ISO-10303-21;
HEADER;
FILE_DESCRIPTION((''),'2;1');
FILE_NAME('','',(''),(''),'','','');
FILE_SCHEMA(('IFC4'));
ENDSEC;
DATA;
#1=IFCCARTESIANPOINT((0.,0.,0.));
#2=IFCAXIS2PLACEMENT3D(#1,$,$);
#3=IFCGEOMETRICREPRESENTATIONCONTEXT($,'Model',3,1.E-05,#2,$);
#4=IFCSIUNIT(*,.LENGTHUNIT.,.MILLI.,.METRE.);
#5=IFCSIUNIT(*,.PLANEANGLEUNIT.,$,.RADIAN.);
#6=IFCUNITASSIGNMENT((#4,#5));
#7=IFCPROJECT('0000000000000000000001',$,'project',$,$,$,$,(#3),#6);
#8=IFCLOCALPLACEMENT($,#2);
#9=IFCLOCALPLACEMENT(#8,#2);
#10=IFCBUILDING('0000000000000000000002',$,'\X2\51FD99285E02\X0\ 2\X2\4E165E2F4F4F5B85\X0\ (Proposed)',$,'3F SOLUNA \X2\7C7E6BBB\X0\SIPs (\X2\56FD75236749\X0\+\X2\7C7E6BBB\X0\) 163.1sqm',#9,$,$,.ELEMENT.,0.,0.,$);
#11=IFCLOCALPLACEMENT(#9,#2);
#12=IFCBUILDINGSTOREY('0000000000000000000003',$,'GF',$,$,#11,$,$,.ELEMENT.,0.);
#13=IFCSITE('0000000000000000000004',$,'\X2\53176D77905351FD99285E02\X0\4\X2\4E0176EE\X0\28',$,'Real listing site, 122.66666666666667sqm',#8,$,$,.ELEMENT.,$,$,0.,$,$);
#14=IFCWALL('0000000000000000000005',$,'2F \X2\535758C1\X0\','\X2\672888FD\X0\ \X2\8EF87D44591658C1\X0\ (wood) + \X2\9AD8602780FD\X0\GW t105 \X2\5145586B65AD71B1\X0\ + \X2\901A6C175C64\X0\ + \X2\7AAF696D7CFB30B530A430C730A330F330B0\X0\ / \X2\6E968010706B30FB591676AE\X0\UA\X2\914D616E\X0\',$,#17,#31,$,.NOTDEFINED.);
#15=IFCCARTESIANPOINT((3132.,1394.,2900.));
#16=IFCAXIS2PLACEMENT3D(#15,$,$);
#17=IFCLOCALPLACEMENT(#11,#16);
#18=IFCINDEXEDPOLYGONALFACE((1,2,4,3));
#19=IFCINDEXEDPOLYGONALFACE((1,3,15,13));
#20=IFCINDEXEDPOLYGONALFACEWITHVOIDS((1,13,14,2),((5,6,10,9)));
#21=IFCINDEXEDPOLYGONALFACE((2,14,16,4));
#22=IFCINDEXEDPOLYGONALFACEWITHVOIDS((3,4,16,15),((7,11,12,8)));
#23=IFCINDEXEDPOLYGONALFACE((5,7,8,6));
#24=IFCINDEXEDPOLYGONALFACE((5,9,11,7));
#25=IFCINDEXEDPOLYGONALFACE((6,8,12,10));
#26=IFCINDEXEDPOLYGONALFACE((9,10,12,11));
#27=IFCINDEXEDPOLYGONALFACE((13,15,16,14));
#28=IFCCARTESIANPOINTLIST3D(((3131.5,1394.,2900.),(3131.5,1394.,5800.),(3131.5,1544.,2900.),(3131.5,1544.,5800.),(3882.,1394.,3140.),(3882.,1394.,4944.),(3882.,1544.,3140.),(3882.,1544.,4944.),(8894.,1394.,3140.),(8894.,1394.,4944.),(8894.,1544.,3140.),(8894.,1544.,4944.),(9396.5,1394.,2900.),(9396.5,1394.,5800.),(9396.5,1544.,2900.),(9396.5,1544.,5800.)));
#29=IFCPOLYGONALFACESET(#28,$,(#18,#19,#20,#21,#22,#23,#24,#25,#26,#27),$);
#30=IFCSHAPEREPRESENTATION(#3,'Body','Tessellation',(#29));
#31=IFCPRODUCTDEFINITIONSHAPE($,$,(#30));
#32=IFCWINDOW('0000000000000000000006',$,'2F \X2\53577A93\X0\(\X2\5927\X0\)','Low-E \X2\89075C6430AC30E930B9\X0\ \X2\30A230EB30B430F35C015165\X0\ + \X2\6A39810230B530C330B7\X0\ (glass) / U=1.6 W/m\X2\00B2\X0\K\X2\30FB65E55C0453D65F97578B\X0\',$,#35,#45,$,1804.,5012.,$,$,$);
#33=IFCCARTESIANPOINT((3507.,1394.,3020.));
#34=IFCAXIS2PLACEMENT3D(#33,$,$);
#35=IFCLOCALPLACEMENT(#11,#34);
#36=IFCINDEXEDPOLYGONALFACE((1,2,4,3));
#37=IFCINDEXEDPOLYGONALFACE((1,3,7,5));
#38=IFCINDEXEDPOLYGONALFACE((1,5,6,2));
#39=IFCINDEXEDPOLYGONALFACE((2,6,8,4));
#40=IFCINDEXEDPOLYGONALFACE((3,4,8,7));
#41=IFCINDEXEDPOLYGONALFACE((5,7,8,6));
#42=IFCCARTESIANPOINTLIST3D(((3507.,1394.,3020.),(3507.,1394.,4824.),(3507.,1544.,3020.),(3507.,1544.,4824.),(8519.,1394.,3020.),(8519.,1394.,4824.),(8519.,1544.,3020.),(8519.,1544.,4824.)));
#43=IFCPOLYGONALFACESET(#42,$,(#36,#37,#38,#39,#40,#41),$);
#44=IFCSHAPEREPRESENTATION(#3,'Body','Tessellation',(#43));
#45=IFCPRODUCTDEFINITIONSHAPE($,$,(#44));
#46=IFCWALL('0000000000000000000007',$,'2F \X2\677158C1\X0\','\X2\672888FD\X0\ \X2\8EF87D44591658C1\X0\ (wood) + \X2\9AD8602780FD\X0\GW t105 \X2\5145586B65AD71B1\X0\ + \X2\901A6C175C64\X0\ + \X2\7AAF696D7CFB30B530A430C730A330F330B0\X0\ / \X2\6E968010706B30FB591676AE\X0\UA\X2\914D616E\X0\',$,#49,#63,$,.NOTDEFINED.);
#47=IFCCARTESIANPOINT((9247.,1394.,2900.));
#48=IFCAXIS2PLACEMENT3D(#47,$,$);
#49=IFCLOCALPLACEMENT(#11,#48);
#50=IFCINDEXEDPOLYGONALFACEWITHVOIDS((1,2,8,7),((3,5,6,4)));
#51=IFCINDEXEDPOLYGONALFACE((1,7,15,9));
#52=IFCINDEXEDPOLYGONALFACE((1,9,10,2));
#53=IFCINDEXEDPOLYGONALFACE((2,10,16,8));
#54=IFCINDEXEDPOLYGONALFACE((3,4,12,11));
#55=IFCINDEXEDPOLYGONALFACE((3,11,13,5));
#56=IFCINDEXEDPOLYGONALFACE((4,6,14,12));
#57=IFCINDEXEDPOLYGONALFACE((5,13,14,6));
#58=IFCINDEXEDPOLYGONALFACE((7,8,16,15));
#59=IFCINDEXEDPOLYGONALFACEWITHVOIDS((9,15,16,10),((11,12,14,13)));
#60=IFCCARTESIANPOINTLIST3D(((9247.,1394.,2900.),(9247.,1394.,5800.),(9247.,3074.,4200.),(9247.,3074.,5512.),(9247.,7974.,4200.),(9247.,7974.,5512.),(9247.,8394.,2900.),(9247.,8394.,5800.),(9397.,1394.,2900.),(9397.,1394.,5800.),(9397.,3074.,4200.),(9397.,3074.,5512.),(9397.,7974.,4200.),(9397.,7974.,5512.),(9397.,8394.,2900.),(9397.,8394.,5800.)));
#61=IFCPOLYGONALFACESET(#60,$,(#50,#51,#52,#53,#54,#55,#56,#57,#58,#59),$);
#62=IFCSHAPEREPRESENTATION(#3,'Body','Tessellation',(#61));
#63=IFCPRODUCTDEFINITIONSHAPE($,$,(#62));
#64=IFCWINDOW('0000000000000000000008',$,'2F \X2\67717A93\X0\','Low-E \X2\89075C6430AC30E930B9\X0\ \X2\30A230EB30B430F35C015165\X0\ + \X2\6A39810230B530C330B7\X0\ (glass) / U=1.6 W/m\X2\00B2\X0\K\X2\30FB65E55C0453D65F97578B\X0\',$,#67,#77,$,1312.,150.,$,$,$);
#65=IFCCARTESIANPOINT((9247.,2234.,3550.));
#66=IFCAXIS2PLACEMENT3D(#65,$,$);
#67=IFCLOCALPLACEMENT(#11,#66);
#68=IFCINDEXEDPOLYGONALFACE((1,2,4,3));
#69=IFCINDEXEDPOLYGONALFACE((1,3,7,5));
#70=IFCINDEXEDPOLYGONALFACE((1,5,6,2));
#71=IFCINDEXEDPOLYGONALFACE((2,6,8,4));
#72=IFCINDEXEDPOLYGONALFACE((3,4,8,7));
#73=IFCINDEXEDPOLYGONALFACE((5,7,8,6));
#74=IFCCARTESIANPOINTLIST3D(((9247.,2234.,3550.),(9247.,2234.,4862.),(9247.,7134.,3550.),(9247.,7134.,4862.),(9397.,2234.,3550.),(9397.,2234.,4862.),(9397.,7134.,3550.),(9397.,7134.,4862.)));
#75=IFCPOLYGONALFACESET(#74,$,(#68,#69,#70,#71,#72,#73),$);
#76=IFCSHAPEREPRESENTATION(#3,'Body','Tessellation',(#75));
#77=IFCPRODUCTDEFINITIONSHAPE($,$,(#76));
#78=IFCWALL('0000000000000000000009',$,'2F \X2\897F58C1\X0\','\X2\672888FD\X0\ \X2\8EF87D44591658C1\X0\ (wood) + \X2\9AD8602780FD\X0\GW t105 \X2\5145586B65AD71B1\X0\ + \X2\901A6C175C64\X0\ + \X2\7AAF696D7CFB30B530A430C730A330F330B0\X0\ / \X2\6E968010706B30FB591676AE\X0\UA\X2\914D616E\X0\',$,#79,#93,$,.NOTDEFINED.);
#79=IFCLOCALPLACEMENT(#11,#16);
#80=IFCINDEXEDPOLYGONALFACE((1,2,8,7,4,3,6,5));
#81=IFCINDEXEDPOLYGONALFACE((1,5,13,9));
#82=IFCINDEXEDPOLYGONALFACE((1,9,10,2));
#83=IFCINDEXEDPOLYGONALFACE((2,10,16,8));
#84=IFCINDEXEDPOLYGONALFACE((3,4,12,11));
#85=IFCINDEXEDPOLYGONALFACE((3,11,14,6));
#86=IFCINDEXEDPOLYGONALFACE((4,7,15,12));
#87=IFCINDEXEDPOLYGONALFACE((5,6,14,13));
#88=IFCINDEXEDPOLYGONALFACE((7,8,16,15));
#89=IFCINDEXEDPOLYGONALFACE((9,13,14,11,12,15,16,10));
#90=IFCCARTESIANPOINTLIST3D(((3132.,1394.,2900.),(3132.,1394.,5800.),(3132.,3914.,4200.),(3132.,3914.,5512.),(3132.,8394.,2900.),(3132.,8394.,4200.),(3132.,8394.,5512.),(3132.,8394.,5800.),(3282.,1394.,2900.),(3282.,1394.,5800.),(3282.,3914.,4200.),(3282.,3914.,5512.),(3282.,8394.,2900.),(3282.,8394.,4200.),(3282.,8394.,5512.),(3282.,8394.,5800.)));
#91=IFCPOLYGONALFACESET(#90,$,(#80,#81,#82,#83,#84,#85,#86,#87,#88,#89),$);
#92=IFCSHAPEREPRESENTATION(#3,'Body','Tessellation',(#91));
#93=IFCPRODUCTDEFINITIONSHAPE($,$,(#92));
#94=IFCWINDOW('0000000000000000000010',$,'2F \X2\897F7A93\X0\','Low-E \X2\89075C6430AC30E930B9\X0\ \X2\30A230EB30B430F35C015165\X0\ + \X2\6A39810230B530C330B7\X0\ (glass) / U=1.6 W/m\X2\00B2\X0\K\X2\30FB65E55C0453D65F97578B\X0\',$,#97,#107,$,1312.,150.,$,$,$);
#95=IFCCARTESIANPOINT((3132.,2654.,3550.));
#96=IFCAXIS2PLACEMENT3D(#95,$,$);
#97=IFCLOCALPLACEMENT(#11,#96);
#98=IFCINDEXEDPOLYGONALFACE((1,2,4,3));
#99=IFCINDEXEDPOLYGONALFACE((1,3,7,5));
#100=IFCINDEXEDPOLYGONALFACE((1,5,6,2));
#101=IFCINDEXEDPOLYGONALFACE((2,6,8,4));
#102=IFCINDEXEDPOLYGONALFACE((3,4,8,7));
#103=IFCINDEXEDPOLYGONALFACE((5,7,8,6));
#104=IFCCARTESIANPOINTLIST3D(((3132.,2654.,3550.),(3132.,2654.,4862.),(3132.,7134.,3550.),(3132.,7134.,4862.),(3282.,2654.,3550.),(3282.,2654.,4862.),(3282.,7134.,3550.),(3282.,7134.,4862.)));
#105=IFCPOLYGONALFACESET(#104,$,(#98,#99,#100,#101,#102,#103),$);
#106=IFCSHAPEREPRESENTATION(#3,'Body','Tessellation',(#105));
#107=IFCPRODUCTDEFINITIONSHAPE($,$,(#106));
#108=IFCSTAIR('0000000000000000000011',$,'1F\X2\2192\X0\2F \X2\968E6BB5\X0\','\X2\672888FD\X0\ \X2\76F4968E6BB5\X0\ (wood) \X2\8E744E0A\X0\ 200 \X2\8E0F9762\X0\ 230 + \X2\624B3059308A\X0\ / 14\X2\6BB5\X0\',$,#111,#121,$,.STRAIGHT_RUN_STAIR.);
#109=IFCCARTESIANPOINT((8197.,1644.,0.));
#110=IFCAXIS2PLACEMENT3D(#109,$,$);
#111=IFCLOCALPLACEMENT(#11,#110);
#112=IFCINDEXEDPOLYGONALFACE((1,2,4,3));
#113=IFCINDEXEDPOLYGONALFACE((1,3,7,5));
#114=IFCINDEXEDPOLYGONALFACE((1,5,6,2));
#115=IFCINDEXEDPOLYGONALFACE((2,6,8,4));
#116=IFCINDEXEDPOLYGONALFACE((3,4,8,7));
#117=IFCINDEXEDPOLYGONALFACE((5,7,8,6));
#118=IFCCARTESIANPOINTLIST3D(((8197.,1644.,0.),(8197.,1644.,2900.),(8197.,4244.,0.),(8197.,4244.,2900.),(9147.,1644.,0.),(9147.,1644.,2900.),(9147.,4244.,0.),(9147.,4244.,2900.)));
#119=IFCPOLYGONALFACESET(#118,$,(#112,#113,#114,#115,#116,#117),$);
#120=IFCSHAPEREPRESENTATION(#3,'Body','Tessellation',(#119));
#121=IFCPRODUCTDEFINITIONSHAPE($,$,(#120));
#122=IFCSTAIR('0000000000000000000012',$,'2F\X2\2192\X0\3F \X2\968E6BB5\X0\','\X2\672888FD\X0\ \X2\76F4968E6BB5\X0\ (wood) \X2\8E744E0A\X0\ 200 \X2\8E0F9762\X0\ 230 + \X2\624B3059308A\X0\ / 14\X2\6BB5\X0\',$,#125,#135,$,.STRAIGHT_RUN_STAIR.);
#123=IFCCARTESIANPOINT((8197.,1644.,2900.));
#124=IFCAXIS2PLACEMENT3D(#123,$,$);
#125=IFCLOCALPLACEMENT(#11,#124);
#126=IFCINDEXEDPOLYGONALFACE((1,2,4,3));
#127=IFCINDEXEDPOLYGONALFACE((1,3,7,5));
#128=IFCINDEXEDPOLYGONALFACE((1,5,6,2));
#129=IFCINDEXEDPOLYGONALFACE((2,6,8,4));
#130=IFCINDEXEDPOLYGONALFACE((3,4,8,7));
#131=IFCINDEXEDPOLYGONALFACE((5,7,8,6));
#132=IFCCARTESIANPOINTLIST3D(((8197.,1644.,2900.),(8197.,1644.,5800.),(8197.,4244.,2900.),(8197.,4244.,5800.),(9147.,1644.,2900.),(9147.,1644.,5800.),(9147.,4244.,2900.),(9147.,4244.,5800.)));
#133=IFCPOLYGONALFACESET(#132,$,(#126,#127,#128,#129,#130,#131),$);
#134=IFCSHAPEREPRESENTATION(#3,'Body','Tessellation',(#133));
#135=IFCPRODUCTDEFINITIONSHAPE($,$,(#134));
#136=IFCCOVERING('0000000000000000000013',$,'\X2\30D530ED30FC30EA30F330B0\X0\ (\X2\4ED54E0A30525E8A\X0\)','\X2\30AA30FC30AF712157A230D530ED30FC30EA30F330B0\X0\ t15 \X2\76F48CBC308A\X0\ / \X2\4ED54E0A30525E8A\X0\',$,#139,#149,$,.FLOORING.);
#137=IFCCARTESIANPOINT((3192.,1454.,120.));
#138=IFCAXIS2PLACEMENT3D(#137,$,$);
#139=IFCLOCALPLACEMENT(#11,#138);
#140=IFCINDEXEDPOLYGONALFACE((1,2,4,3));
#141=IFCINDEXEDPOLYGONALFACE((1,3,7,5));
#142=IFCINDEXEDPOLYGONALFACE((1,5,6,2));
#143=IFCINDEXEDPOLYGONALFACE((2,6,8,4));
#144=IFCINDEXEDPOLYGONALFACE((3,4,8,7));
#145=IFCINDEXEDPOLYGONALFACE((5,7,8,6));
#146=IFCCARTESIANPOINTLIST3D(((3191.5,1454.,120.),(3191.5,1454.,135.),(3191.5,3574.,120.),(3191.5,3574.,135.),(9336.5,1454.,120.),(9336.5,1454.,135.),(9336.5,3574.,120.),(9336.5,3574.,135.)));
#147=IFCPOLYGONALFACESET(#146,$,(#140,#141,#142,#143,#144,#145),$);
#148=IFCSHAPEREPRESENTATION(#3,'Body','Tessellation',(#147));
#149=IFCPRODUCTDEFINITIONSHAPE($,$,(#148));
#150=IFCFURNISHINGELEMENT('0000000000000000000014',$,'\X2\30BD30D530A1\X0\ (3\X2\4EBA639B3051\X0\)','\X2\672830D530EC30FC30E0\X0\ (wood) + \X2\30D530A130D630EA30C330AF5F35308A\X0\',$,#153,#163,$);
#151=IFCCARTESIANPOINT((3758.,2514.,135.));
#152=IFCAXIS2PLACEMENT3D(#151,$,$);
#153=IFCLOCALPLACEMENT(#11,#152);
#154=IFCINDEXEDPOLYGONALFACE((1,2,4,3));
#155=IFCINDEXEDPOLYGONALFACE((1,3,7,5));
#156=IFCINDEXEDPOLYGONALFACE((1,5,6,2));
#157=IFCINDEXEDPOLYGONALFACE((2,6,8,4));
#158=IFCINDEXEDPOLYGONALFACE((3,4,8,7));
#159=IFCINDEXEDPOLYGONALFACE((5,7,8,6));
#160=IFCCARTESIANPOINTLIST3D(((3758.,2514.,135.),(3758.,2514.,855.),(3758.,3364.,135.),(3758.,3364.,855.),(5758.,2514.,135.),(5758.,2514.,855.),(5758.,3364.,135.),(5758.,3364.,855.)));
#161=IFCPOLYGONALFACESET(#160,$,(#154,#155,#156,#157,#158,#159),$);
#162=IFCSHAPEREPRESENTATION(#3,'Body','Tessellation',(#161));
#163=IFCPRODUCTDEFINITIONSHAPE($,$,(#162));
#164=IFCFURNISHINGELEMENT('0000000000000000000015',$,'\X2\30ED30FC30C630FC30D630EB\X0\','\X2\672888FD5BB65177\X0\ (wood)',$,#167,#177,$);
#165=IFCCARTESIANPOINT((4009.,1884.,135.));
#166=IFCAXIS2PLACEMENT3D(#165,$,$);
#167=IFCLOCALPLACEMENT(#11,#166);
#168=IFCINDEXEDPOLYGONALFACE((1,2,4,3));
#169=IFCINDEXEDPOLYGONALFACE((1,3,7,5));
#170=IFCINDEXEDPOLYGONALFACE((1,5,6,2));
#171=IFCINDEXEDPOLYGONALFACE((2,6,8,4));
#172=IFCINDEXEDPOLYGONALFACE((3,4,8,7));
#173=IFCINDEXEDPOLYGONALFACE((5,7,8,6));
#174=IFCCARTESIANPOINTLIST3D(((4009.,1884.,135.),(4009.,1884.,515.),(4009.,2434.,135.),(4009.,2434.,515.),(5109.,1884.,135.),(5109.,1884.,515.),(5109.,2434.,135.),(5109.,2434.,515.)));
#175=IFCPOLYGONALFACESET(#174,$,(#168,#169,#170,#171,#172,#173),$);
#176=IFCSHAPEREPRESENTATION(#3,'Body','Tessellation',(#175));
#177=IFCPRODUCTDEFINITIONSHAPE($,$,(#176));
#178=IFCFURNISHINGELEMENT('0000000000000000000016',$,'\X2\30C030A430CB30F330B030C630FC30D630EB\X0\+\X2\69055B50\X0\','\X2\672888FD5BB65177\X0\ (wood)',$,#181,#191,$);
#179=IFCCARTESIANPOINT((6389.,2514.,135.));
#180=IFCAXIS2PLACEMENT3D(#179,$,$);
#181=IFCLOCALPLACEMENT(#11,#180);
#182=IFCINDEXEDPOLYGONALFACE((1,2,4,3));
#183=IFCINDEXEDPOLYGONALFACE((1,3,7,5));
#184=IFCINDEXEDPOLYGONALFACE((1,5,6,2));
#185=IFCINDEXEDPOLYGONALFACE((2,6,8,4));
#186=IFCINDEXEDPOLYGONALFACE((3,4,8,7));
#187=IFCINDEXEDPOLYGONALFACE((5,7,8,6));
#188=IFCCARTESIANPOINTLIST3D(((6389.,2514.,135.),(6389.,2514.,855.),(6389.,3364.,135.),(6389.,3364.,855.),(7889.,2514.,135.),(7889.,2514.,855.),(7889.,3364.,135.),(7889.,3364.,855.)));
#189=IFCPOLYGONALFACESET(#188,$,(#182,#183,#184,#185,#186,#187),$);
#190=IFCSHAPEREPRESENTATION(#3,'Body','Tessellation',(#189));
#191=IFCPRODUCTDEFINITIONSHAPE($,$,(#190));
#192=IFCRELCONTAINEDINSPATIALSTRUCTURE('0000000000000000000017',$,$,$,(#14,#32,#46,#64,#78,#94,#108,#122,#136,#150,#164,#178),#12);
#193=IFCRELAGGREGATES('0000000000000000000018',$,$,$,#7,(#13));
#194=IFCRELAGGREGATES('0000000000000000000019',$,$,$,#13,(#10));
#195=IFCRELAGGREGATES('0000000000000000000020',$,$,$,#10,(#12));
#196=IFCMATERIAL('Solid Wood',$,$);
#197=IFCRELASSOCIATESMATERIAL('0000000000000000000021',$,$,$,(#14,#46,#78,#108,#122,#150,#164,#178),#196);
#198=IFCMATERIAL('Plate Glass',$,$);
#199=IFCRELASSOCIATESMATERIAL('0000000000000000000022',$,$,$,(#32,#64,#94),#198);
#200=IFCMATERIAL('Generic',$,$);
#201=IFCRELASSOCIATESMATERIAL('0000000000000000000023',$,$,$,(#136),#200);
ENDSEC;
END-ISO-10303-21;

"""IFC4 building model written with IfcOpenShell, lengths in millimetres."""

from ifc_helpers import new_model, si_unit, frame, frame_2d, origin, place, context, project, spatial, rectangle, extrude, material, element, fill, save


model = new_model("IFC4")

# Units and contexts
model_context = context("Model", 3, precision=1e-05, world=origin())
ifc_project = project(units=[si_unit("LENGTHUNIT", "METRE", prefix="MILLI"), si_unit("PLANEANGLEUNIT", "RADIAN")], contexts=[model_context])

# Site, building, storey
site_placement = place(None, origin())
site = spatial("IfcSite", under=ifc_project, at=site_placement, Name="北海道函館市4丁目28", ObjectType="Real listing site, 122.66666666666667sqm", CompositionType="ELEMENT", RefElevation=0.0)
building_placement = place(site_placement, origin())
building = spatial("IfcBuilding", under=site, at=building_placement, Name="函館市 2世帯住宅 (Proposed)", ObjectType="3F SOLUNA 籾殻SIPs (国産杉+籾殻) 163.1sqm", CompositionType="ELEMENT", ElevationOfRefHeight=0.0, ElevationOfTerrain=0.0)
storey_placement = place(building_placement, origin())
storey = spatial("IfcBuildingStorey", under=building, at=storey_placement, Name="GF", CompositionType="ELEMENT", Elevation=0.0)

# Shared definitions
ifc_material_1 = material(Name="Solid Wood")

# Shared definitions
ifc_material_2 = material(Name="Plate Glass")

# Walls, openings, windows
wall_1_placement = place(storey_placement, frame((3132.0, 1394.0, 2900.0)))
wall_1 = element("IfcWall", 1, at=wall_1_placement, inside=storey, material=ifc_material_1, Name="2F 南壁", Description="木製 軸組外壁 (wood) + 高性能GW t105 充填断熱 + 通気層 + 窯業系サイディング / 準耐火・外皮UA配慮", PredefinedType="NOTDEFINED", context=model_context, shape_type="SweptSolid", body=[
    extrude(rectangle(XDim=6265.0, YDim=150.0, at=frame_2d((3132.0, 75.0))), frame((3132.0, 1394.0, 2900.0)), (0.0, 0.0, 1.0), 2900.0),
])
opening_1_placement = place(storey_placement, frame((3507.0, 1394.0, 3020.0)))
opening_1 = element("IfcOpeningElement", 2, at=opening_1_placement, cuts=wall_1, PredefinedType="NOTDEFINED", context=model_context, shape_type="SweptSolid", body=[
    extrude(rectangle(XDim=5012.0, YDim=150.0, at=frame_2d((2506.0, 75.0))), frame((3507.0, 1394.0, 3020.0)), (0.0, 0.0, 1.0), 1804.0),
])
window_1_placement = place(storey_placement, frame((3507.0, 1394.0, 3020.0)))
window_1 = element("IfcWindow", 3, at=window_1_placement, inside=storey, material=ifc_material_2, Name="2F 南窓(大)", Description="Low-E 複層ガラス アルゴン封入 + 樹脂サッシ (glass) / U=1.6 W/m²K・日射取得型", OverallHeight=1804.0, OverallWidth=5012.0, context=model_context, shape_type="SweptSolid", body=[
    extrude(rectangle(XDim=5012.0, YDim=150.0, at=frame_2d((2506.0, 75.0))), frame((3507.0, 1394.0, 3020.0)), (0.0, 0.0, 1.0), 1804.0),
])
fill(opening_1, window_1)
wall_2_placement = place(storey_placement, frame((9247.0, 1394.0, 2900.0)))
wall_2 = element("IfcWall", 4, at=wall_2_placement, inside=storey, material=ifc_material_1, Name="2F 東壁", Description="木製 軸組外壁 (wood) + 高性能GW t105 充填断熱 + 通気層 + 窯業系サイディング / 準耐火・外皮UA配慮", PredefinedType="NOTDEFINED", context=model_context, shape_type="SweptSolid", body=[
    extrude(rectangle(XDim=150.0, YDim=7000.0, at=frame_2d((75.0, 3500.0))), frame((9247.0, 1394.0, 2900.0)), (0.0, 0.0, 1.0), 2900.0),
])
opening_2_placement = place(storey_placement, frame((9247.0, 2234.0, 3550.0)))
opening_2 = element("IfcOpeningElement", 5, at=opening_2_placement, cuts=wall_2, PredefinedType="NOTDEFINED", context=model_context, shape_type="SweptSolid", body=[
    extrude(rectangle(XDim=150.0, YDim=4900.0, at=frame_2d((75.0, 2450.0))), frame((9247.0, 2234.0, 3550.0)), (0.0, 0.0, 1.0), 1312.0),
])
window_2_placement = place(storey_placement, frame((9247.0, 2234.0, 3550.0)))
window_2 = element("IfcWindow", 6, at=window_2_placement, inside=storey, material=ifc_material_2, Name="2F 東窓", Description="Low-E 複層ガラス アルゴン封入 + 樹脂サッシ (glass) / U=1.6 W/m²K・日射取得型", OverallHeight=1312.0, OverallWidth=150.0, context=model_context, shape_type="SweptSolid", body=[
    extrude(rectangle(XDim=150.0, YDim=4900.0, at=frame_2d((75.0, 2450.0))), frame((9247.0, 2234.0, 3550.0)), (0.0, 0.0, 1.0), 1312.0),
])
fill(opening_2, window_2)
wall_3_placement = place(storey_placement, frame((3132.0, 1394.0, 2900.0)))
wall_3 = element("IfcWall", 7, at=wall_3_placement, inside=storey, material=ifc_material_1, Name="2F 西壁", Description="木製 軸組外壁 (wood) + 高性能GW t105 充填断熱 + 通気層 + 窯業系サイディング / 準耐火・外皮UA配慮", PredefinedType="NOTDEFINED", context=model_context, shape_type="SweptSolid", body=[
    extrude(rectangle(XDim=150.0, YDim=7000.0, at=frame_2d((75.0, 3500.0))), frame((3132.0, 1394.0, 2900.0)), (0.0, 0.0, 1.0), 2900.0),
])
opening_3_placement = place(storey_placement, frame((3132.0, 2654.0, 3550.0)))
opening_3 = element("IfcOpeningElement", 8, at=opening_3_placement, cuts=wall_3, PredefinedType="NOTDEFINED", context=model_context, shape_type="SweptSolid", body=[
    extrude(rectangle(XDim=150.0, YDim=4480.0, at=frame_2d((75.0, 2240.0))), frame((3132.0, 2654.0, 3550.0)), (0.0, 0.0, 1.0), 1312.0),
])
window_3_placement = place(storey_placement, frame((3132.0, 2654.0, 3550.0)))
window_3 = element("IfcWindow", 9, at=window_3_placement, inside=storey, material=ifc_material_2, Name="2F 西窓", Description="Low-E 複層ガラス アルゴン封入 + 樹脂サッシ (glass) / U=1.6 W/m²K・日射取得型", OverallHeight=1312.0, OverallWidth=150.0, context=model_context, shape_type="SweptSolid", body=[
    extrude(rectangle(XDim=150.0, YDim=4480.0, at=frame_2d((75.0, 2240.0))), frame((3132.0, 2654.0, 3550.0)), (0.0, 0.0, 1.0), 1312.0),
])
fill(opening_3, window_3)

# Stairs
stair_1_placement = place(storey_placement, frame((8197.0, 1644.0, 0.0)))
element("IfcStair", 10, at=stair_1_placement, inside=storey, material=ifc_material_1, Name="1F→2F 階段", Description="木製 直階段 (wood) 蹴上 200 踏面 230 + 手すり / 14段", PredefinedType="STRAIGHT_RUN_STAIR", context=model_context, shape_type="SweptSolid", body=[
    extrude(rectangle(XDim=950.0, YDim=2600.0, at=frame_2d((475.0, 1300.0))), frame((8197.0, 1644.0, 0.0)), (0.0, 0.0, 1.0), 2900.0),
])
stair_2_placement = place(storey_placement, frame((8197.0, 1644.0, 2900.0)))
element("IfcStair", 11, at=stair_2_placement, inside=storey, material=ifc_material_1, Name="2F→3F 階段", Description="木製 直階段 (wood) 蹴上 200 踏面 230 + 手すり / 14段", PredefinedType="STRAIGHT_RUN_STAIR", context=model_context, shape_type="SweptSolid", body=[
    extrude(rectangle(XDim=950.0, YDim=2600.0, at=frame_2d((475.0, 1300.0))), frame((8197.0, 1644.0, 2900.0)), (0.0, 0.0, 1.0), 2900.0),
])

# Covering
ifc_material_3 = material(Name="Generic")
covering_placement = place(storey_placement, frame((3192.0, 1454.0, 120.0)))
element("IfcCovering", 12, at=covering_placement, inside=storey, material=ifc_material_3, Name="フローリング (仕上げ床)", Description="オーク無垢フローリング t15 直貼り / 仕上げ床", PredefinedType="FLOORING", context=model_context, shape_type="SweptSolid", body=[
    extrude(rectangle(XDim=6145.0, YDim=2120.0, at=frame_2d((3072.0, 1060.0))), frame((3192.0, 1454.0, 120.0)), (0.0, 0.0, 1.0), 15.0),
])

# Furnishing elements
furnishing_1_placement = place(storey_placement, frame((3758.0, 2514.0, 135.0)))
element("IfcFurnishingElement", 13, at=furnishing_1_placement, inside=storey, material=ifc_material_1, Name="ソファ (3人掛け)", Description="木フレーム (wood) + ファブリック張り", context=model_context, shape_type="SweptSolid", body=[
    extrude(rectangle(XDim=2000.0, YDim=850.0, at=frame_2d((1000.0, 425.0))), frame((3758.0, 2514.0, 135.0)), (0.0, 0.0, 1.0), 720.0),
])
furnishing_2_placement = place(storey_placement, frame((4009.0, 1884.0, 135.0)))
element("IfcFurnishingElement", 14, at=furnishing_2_placement, inside=storey, material=ifc_material_1, Name="ローテーブル", Description="木製家具 (wood)", context=model_context, shape_type="SweptSolid", body=[
    extrude(rectangle(XDim=1100.0, YDim=550.0, at=frame_2d((550.0, 275.0))), frame((4009.0, 1884.0, 135.0)), (0.0, 0.0, 1.0), 380.0),
])
furnishing_3_placement = place(storey_placement, frame((6389.0, 2514.0, 135.0)))
element("IfcFurnishingElement", 15, at=furnishing_3_placement, inside=storey, material=ifc_material_1, Name="ダイニングテーブル+椅子", Description="木製家具 (wood)", context=model_context, shape_type="SweptSolid", body=[
    extrude(rectangle(XDim=1500.0, YDim=850.0, at=frame_2d((750.0, 425.0))), frame((6389.0, 2514.0, 135.0)), (0.0, 0.0, 1.0), 720.0),
])

save(model, "model.ifc")
